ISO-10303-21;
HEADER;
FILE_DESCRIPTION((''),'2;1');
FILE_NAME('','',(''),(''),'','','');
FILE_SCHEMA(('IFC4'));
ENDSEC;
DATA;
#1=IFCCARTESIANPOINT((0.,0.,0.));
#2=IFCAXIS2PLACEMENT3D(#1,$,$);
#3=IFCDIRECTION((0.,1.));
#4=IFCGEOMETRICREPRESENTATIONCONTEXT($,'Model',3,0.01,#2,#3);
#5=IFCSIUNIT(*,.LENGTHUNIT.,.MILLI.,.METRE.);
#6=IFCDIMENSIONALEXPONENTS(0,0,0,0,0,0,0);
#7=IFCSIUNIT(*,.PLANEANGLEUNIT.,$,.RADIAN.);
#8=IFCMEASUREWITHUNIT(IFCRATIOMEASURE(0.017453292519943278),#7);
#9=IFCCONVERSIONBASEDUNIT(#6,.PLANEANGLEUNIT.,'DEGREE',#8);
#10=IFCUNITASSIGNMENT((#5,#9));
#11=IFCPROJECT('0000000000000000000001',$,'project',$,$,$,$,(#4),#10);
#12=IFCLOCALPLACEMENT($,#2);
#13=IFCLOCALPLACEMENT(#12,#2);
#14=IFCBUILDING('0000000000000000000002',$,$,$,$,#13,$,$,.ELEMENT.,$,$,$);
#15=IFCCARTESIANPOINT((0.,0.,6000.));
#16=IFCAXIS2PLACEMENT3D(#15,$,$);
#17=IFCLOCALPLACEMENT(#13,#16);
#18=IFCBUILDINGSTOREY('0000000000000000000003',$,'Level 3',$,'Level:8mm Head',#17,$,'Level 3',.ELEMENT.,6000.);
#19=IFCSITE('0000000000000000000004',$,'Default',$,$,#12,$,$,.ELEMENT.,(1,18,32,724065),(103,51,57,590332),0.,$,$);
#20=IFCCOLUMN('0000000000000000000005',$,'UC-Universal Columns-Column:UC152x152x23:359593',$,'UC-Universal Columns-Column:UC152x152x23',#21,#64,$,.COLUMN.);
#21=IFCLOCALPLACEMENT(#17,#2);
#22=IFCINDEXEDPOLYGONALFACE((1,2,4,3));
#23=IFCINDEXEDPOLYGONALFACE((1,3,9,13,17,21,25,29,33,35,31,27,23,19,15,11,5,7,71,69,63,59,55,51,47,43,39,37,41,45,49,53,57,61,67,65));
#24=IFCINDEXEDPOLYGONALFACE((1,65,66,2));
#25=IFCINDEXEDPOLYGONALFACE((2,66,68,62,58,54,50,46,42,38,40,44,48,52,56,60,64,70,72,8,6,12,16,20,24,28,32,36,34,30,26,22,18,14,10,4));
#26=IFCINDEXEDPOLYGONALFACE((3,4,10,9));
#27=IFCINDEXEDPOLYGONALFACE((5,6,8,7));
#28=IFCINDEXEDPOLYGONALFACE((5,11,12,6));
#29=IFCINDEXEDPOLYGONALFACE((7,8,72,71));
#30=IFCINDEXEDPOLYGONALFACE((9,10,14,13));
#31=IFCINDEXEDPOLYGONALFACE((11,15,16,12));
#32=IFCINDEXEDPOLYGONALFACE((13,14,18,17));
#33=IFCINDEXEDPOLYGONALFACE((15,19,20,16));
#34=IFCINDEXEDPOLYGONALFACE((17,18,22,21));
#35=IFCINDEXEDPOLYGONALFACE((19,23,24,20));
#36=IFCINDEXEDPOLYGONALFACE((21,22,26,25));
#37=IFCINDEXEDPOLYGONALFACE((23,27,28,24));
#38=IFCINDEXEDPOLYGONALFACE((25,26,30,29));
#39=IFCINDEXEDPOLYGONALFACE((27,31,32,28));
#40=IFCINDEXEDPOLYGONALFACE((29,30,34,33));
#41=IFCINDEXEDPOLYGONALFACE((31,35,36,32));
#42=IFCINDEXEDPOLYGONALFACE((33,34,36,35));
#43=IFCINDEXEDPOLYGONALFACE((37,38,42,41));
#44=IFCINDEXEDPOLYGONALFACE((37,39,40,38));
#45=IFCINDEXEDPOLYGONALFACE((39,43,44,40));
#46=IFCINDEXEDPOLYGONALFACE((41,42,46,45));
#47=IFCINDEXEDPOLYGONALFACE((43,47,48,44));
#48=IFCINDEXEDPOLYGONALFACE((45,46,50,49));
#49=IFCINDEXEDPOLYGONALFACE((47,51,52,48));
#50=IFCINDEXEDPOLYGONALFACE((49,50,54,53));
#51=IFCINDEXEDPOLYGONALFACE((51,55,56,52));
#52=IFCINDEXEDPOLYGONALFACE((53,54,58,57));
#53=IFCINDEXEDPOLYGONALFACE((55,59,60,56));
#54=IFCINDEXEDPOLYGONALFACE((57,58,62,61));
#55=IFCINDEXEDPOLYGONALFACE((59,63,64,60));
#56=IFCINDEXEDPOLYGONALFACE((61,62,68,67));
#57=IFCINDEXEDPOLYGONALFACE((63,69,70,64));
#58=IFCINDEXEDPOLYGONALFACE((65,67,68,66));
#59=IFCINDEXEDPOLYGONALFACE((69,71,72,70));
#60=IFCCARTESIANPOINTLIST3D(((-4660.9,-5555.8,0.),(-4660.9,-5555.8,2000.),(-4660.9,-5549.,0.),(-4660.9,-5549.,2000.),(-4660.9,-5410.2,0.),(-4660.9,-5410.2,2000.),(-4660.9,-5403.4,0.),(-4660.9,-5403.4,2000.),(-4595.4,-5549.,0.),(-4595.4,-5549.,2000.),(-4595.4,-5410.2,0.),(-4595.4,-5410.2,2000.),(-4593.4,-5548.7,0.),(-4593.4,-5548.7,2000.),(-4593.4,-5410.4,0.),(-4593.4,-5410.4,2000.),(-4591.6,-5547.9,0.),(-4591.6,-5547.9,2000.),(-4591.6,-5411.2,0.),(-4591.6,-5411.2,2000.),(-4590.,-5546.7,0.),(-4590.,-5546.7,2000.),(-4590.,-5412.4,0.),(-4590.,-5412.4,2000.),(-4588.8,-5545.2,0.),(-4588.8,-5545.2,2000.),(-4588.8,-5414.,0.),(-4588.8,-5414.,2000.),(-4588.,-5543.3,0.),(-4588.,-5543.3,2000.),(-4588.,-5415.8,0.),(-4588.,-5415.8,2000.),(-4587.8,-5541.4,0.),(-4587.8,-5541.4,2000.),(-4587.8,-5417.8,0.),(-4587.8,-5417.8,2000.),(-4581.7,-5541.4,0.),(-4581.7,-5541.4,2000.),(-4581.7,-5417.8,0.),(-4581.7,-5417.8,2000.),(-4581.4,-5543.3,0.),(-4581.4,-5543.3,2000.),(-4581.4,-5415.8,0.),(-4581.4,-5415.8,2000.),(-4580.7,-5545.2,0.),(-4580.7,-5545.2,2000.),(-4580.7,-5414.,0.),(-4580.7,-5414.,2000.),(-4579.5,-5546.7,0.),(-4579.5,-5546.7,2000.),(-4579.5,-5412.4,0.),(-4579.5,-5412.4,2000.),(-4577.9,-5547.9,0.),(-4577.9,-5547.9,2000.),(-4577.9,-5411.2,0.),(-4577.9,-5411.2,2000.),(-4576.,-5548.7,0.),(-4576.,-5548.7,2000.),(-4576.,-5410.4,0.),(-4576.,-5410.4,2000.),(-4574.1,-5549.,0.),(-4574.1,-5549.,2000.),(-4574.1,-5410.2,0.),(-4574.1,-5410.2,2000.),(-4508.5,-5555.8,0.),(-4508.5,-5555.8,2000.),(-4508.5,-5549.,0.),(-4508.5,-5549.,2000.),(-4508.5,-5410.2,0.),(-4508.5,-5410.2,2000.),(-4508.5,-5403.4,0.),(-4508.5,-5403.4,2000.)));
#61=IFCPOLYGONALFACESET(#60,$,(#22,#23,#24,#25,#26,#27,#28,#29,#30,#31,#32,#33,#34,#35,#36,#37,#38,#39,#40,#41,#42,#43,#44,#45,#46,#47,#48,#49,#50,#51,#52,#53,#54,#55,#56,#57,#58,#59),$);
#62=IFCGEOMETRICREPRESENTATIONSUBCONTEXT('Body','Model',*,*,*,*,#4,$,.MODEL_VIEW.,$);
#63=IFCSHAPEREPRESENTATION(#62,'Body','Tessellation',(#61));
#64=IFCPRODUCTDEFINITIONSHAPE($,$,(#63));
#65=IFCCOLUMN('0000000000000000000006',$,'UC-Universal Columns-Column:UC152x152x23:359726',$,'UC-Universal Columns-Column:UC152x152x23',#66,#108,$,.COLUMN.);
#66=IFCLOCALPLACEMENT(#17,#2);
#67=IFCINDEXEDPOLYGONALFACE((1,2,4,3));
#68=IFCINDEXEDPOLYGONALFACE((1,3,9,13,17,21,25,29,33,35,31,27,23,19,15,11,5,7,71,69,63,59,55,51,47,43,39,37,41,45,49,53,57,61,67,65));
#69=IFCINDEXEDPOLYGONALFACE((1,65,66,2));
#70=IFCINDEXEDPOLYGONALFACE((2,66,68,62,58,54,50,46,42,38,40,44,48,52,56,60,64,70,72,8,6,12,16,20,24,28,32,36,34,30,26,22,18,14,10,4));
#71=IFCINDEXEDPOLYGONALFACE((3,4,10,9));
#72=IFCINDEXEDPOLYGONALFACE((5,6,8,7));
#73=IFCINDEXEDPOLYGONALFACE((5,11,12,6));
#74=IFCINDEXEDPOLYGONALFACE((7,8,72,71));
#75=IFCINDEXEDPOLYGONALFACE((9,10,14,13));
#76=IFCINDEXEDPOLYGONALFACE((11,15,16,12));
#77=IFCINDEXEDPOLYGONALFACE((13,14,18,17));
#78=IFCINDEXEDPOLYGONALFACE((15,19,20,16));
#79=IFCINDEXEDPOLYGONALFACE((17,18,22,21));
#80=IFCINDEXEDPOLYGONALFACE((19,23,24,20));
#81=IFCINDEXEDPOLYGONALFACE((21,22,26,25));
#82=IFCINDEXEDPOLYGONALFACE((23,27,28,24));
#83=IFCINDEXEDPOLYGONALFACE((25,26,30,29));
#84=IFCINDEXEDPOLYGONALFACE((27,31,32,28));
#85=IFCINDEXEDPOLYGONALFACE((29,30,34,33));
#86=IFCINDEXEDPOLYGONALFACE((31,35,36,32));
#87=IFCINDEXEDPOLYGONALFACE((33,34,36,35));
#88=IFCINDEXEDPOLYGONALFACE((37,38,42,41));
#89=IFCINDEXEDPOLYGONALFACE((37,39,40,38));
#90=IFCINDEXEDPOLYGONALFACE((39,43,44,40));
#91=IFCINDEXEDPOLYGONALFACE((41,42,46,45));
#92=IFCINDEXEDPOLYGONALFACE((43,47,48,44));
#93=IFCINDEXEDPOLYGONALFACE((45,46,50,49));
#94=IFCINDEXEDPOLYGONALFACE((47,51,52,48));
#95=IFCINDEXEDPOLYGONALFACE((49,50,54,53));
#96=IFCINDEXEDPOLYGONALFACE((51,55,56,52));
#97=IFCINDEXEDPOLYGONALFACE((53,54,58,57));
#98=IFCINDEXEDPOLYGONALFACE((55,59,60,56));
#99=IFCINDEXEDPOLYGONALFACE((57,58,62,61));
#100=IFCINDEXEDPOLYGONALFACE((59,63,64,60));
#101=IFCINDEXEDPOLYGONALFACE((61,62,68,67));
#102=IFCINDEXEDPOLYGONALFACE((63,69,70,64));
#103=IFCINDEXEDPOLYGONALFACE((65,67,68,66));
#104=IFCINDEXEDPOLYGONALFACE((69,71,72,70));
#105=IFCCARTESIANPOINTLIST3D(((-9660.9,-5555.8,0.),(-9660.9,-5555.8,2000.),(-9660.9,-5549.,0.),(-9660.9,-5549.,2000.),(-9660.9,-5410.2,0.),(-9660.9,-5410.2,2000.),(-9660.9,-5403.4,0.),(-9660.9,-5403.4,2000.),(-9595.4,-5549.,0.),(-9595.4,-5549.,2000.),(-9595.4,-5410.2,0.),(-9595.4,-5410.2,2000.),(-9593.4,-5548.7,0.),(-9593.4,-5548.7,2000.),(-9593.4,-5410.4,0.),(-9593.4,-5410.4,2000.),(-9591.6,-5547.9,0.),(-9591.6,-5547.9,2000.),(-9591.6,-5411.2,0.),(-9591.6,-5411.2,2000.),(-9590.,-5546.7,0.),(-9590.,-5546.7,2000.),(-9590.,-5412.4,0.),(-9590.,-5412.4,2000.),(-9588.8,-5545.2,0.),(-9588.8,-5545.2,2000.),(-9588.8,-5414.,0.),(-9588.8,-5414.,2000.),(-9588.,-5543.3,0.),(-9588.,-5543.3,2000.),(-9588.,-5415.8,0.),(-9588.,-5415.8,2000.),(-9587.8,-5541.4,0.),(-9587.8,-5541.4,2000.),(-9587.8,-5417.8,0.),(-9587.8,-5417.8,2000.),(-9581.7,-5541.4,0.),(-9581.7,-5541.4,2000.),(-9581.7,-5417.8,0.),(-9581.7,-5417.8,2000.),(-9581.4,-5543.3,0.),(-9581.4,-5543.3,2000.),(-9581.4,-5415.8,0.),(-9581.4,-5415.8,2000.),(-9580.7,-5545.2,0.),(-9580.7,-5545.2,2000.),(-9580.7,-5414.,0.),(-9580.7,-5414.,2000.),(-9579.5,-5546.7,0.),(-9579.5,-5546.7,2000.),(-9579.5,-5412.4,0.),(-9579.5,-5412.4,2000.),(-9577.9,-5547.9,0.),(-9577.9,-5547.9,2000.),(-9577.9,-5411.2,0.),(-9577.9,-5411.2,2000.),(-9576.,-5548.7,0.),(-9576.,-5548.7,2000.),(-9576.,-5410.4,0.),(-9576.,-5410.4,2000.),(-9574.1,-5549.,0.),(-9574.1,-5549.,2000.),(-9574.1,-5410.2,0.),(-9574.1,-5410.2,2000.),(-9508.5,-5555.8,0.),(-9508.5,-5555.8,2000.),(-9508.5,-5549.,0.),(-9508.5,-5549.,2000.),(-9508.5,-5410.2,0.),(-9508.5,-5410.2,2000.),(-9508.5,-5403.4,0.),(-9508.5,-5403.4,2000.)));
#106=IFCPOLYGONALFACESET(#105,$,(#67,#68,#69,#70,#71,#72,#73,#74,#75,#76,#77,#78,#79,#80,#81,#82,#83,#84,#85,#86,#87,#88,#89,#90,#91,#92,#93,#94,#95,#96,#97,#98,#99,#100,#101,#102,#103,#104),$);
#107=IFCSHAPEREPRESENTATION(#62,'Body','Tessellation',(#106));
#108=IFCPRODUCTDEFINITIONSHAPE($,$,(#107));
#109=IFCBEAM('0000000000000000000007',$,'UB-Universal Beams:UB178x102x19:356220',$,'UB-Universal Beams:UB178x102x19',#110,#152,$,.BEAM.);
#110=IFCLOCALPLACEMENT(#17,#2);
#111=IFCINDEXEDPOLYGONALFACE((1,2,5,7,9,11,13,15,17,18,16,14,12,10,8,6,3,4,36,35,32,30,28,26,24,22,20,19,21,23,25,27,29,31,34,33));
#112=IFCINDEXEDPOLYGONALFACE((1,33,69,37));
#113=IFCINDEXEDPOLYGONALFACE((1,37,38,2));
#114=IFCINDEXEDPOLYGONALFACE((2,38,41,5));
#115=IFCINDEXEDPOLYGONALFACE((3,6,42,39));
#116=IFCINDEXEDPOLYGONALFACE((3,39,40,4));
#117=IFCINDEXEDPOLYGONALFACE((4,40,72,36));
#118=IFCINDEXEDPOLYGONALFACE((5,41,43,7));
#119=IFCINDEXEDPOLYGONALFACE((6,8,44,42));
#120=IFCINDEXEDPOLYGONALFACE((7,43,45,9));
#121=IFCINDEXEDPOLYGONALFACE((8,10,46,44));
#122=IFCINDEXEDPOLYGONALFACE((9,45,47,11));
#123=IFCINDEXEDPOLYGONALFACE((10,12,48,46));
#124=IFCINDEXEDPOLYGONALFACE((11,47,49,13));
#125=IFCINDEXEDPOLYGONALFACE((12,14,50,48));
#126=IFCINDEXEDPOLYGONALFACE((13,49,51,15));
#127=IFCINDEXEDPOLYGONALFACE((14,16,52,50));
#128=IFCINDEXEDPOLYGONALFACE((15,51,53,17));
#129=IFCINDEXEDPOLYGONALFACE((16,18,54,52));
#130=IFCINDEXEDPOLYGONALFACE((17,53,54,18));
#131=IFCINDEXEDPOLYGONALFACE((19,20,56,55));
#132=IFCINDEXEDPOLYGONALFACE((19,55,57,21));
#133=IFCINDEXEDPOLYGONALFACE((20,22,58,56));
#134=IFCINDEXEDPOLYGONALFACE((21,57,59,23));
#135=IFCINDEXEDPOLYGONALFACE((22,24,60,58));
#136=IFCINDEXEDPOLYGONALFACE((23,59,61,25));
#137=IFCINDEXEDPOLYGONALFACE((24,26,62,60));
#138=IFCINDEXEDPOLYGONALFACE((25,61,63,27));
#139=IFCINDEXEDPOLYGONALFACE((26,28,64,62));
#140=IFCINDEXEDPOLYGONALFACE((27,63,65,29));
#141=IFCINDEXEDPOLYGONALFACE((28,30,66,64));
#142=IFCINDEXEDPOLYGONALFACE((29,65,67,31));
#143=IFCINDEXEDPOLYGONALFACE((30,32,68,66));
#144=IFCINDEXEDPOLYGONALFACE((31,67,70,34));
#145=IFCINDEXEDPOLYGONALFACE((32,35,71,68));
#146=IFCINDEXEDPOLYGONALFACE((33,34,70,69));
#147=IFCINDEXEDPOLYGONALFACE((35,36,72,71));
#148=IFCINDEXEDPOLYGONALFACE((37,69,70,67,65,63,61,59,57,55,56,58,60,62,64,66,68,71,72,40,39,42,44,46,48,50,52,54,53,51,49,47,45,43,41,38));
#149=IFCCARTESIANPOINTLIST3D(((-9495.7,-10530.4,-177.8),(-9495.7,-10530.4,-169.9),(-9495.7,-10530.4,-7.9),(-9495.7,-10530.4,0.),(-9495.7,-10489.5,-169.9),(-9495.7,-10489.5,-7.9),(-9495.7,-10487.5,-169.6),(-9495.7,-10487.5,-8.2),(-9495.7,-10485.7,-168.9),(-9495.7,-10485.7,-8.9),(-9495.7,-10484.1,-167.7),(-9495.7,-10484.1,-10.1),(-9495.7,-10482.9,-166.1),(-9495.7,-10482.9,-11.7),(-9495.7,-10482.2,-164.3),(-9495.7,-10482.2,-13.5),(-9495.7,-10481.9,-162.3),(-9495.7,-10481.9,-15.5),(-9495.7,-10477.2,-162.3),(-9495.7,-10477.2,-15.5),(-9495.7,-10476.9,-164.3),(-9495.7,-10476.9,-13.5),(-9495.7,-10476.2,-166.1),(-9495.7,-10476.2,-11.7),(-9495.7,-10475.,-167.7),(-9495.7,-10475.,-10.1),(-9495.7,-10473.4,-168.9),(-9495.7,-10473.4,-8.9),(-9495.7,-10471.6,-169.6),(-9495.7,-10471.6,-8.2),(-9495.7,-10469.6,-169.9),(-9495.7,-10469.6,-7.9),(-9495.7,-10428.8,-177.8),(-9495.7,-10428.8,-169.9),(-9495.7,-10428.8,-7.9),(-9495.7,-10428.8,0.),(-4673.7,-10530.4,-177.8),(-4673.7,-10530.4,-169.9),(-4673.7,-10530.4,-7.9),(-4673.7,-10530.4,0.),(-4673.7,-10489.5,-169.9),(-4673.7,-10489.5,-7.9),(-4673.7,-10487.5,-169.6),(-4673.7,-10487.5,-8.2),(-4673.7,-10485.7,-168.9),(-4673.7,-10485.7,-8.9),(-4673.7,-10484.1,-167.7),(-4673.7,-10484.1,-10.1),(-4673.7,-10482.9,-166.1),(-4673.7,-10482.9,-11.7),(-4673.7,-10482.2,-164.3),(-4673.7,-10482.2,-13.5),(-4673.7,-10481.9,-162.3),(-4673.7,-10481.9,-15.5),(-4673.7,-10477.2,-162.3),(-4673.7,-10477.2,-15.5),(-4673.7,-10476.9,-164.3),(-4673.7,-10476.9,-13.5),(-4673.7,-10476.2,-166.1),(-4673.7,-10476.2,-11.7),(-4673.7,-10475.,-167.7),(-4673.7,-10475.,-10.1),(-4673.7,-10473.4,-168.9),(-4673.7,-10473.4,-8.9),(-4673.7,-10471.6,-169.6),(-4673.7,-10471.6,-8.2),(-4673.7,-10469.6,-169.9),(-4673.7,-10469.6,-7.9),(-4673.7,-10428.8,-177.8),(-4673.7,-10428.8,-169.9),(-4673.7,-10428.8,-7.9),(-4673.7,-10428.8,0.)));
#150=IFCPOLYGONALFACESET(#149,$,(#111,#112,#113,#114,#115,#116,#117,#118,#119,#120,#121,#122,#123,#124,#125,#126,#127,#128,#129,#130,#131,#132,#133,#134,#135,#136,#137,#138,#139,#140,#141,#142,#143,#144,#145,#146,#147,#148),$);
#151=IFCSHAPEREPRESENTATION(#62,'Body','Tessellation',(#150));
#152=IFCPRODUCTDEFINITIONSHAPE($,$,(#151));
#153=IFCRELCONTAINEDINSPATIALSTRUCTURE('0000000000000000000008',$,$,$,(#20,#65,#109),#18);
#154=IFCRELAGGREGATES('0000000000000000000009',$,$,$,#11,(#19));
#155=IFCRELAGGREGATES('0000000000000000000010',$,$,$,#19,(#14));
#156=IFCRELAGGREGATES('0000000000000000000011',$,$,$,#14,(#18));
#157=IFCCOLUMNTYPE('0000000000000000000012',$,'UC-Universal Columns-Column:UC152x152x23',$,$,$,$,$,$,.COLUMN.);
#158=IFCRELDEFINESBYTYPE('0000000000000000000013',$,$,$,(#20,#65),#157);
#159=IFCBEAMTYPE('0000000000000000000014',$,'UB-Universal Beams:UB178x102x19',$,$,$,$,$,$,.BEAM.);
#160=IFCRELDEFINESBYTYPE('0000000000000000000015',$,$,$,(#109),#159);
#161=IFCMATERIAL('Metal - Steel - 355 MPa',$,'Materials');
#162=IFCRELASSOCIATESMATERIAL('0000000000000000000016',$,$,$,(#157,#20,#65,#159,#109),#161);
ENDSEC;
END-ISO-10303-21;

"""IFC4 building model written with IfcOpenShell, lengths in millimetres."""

from ifc_helpers import new_model, entity, si_unit, converted_unit, direction, frame, origin, place, context, subcontext, project, spatial, line, arc, indexed_curve, outline, extrude, source, transform, mapped, material, type_object, type_shapes, element, save


model = new_model("IFC4")

# Units and contexts
model_context = context("Model", 3, precision=0.01, world=origin(), true_north=direction((0.0, 1.0)))
body_context = subcontext(model_context, "Body", "Model", "MODEL_VIEW")
ifc_project = project(units=[si_unit("LENGTHUNIT", "METRE", prefix="MILLI"), converted_unit("PLANEANGLEUNIT", "DEGREE", entity("IfcRatioMeasure", 0.017453292519943278), si_unit("PLANEANGLEUNIT", "RADIAN"), dimensions=[0, 0, 0, 0, 0, 0, 0])], contexts=[model_context])

# Site, building, storey
site_placement = place(None, origin())
site = spatial("IfcSite", under=ifc_project, at=site_placement, Name="Default", CompositionType="ELEMENT", RefLatitude=(1, 18, 32, 724065), RefLongitude=(103, 51, 57, 590332), RefElevation=0.0)
building_placement = place(site_placement, origin())
building = spatial("IfcBuilding", under=site, at=building_placement, CompositionType="ELEMENT")
storey_placement = place(building_placement, frame((0.0, 0.0, 6000.0)))
storey = spatial("IfcBuildingStorey", under=building, at=storey_placement, Name="Level 3", ObjectType="Level:8mm Head", LongName="Level 3", CompositionType="ELEMENT", Elevation=6000.0)

# Columns
ifc_material = material(Name="Metal - Steel - 355 MPa", Category="Materials")
column_type = type_object("IfcColumnType", Name="UC-Universal Columns-Column:UC152x152x23", PredefinedType="COLUMN", material=ifc_material)
shared_shape_1 = source(origin(), body_context, "Body", "SweptSolid", [
    extrude(outline(indexed_curve([(69.4, -76.2), (76.2, -76.2), (76.2, 76.2), (69.4, 76.2), (69.4, 10.7), (67.2, 5.3), (61.8, 3.1), (-61.8, 3.1), (-67.2, 5.3), (-69.4, 10.7), (-69.4, 76.2), (-76.2, 76.2), (-76.2, -76.2), (-69.4, -76.2), (-69.4, -10.7), (-67.2, -5.3), (-61.8, -3.0), (61.8, -3.1), (67.2, -5.3), (69.4, -10.6)], segments=[line(1, 2, 3, 4, 5), arc(5, 6, 7), line(7, 8), arc(8, 9, 10), line(10, 11, 12, 13, 14, 15), arc(15, 16, 17), line(17, 18), arc(18, 19, 20), line(20, 1)], self_intersect=False)), frame((0.0, 0.0, 6000.0), z_axis=(0.0, 0.0, 1.0), x_axis=(0.0, -1.0, 0.0)), (0.0, 0.0, 1.0), 2000.0),
])
type_shapes(column_type, [shared_shape_1])
for number, where, name in (
    (1, (-4584.7, -5479.6, -6000.0), "UC-Universal Columns-Column:UC152x152x23:359593"),
    (2, (-9584.7, -5479.6, -6000.0), "UC-Universal Columns-Column:UC152x152x23:359726"),
):
    element("IfcColumn", number, at=place(storey_placement, frame(where)), inside=storey, type_object=column_type, material=ifc_material, Name=name, ObjectType="UC-Universal Columns-Column:UC152x152x23", PredefinedType="COLUMN", context=body_context, shape_type="MappedRepresentation", body=[
        mapped(shared_shape_1, transform((0.0, 0.0, 0.0), scale=1.0)),
    ])

# Beam
beam_type_1 = type_object("IfcBeamType", Name="UB-Universal Beams:UB178x102x19", PredefinedType="BEAM", material=ifc_material)
shared_shape_2 = source(origin(), body_context, "Body", "SweptSolid", [
    extrude(outline(indexed_curve([(-88.9, -50.8), (-81.0, -50.8), (-81.0, -9.9), (-78.8, -4.6), (-73.4, -2.3), (73.4, -2.3), (78.8, -4.6), (81.0, -9.9), (81.0, -50.8), (88.9, -50.8), (88.9, 50.8), (81.0, 50.8), (81.0, 10.0), (78.8, 4.6), (73.4, 2.4), (-73.4, 2.4), (-78.8, 4.6), (-81.0, 10.0), (-81.0, 50.8), (-88.9, 50.8)], segments=[line(1, 2, 3), arc(3, 4, 5), line(5, 6), arc(6, 7, 8), line(8, 9, 10, 11, 12, 13), arc(13, 14, 15), line(15, 16), arc(16, 17, 18), line(18, 19, 20, 1)], self_intersect=False)), frame((-2411.0, 0.0, 0.0), z_axis=(1.0, 0.0, 0.0), x_axis=(0.0, 0.0, -1.0)), (0.0, 0.0, 1.0), 4822.0),
])
type_shapes(beam_type_1, [shared_shape_2])
beam_placement = place(storey_placement, frame((-7084.7, -10479.6, -88.9)))
element("IfcBeam", 3, at=beam_placement, inside=storey, type_object=beam_type_1, material=ifc_material, Name="UB-Universal Beams:UB178x102x19:356220", ObjectType="UB-Universal Beams:UB178x102x19", PredefinedType="BEAM", context=body_context, shape_type="MappedRepresentation", body=[
    mapped(shared_shape_2, transform((0.0, 0.0, 0.0), scale=1.0)),
])

save(model, "model.ifc")
